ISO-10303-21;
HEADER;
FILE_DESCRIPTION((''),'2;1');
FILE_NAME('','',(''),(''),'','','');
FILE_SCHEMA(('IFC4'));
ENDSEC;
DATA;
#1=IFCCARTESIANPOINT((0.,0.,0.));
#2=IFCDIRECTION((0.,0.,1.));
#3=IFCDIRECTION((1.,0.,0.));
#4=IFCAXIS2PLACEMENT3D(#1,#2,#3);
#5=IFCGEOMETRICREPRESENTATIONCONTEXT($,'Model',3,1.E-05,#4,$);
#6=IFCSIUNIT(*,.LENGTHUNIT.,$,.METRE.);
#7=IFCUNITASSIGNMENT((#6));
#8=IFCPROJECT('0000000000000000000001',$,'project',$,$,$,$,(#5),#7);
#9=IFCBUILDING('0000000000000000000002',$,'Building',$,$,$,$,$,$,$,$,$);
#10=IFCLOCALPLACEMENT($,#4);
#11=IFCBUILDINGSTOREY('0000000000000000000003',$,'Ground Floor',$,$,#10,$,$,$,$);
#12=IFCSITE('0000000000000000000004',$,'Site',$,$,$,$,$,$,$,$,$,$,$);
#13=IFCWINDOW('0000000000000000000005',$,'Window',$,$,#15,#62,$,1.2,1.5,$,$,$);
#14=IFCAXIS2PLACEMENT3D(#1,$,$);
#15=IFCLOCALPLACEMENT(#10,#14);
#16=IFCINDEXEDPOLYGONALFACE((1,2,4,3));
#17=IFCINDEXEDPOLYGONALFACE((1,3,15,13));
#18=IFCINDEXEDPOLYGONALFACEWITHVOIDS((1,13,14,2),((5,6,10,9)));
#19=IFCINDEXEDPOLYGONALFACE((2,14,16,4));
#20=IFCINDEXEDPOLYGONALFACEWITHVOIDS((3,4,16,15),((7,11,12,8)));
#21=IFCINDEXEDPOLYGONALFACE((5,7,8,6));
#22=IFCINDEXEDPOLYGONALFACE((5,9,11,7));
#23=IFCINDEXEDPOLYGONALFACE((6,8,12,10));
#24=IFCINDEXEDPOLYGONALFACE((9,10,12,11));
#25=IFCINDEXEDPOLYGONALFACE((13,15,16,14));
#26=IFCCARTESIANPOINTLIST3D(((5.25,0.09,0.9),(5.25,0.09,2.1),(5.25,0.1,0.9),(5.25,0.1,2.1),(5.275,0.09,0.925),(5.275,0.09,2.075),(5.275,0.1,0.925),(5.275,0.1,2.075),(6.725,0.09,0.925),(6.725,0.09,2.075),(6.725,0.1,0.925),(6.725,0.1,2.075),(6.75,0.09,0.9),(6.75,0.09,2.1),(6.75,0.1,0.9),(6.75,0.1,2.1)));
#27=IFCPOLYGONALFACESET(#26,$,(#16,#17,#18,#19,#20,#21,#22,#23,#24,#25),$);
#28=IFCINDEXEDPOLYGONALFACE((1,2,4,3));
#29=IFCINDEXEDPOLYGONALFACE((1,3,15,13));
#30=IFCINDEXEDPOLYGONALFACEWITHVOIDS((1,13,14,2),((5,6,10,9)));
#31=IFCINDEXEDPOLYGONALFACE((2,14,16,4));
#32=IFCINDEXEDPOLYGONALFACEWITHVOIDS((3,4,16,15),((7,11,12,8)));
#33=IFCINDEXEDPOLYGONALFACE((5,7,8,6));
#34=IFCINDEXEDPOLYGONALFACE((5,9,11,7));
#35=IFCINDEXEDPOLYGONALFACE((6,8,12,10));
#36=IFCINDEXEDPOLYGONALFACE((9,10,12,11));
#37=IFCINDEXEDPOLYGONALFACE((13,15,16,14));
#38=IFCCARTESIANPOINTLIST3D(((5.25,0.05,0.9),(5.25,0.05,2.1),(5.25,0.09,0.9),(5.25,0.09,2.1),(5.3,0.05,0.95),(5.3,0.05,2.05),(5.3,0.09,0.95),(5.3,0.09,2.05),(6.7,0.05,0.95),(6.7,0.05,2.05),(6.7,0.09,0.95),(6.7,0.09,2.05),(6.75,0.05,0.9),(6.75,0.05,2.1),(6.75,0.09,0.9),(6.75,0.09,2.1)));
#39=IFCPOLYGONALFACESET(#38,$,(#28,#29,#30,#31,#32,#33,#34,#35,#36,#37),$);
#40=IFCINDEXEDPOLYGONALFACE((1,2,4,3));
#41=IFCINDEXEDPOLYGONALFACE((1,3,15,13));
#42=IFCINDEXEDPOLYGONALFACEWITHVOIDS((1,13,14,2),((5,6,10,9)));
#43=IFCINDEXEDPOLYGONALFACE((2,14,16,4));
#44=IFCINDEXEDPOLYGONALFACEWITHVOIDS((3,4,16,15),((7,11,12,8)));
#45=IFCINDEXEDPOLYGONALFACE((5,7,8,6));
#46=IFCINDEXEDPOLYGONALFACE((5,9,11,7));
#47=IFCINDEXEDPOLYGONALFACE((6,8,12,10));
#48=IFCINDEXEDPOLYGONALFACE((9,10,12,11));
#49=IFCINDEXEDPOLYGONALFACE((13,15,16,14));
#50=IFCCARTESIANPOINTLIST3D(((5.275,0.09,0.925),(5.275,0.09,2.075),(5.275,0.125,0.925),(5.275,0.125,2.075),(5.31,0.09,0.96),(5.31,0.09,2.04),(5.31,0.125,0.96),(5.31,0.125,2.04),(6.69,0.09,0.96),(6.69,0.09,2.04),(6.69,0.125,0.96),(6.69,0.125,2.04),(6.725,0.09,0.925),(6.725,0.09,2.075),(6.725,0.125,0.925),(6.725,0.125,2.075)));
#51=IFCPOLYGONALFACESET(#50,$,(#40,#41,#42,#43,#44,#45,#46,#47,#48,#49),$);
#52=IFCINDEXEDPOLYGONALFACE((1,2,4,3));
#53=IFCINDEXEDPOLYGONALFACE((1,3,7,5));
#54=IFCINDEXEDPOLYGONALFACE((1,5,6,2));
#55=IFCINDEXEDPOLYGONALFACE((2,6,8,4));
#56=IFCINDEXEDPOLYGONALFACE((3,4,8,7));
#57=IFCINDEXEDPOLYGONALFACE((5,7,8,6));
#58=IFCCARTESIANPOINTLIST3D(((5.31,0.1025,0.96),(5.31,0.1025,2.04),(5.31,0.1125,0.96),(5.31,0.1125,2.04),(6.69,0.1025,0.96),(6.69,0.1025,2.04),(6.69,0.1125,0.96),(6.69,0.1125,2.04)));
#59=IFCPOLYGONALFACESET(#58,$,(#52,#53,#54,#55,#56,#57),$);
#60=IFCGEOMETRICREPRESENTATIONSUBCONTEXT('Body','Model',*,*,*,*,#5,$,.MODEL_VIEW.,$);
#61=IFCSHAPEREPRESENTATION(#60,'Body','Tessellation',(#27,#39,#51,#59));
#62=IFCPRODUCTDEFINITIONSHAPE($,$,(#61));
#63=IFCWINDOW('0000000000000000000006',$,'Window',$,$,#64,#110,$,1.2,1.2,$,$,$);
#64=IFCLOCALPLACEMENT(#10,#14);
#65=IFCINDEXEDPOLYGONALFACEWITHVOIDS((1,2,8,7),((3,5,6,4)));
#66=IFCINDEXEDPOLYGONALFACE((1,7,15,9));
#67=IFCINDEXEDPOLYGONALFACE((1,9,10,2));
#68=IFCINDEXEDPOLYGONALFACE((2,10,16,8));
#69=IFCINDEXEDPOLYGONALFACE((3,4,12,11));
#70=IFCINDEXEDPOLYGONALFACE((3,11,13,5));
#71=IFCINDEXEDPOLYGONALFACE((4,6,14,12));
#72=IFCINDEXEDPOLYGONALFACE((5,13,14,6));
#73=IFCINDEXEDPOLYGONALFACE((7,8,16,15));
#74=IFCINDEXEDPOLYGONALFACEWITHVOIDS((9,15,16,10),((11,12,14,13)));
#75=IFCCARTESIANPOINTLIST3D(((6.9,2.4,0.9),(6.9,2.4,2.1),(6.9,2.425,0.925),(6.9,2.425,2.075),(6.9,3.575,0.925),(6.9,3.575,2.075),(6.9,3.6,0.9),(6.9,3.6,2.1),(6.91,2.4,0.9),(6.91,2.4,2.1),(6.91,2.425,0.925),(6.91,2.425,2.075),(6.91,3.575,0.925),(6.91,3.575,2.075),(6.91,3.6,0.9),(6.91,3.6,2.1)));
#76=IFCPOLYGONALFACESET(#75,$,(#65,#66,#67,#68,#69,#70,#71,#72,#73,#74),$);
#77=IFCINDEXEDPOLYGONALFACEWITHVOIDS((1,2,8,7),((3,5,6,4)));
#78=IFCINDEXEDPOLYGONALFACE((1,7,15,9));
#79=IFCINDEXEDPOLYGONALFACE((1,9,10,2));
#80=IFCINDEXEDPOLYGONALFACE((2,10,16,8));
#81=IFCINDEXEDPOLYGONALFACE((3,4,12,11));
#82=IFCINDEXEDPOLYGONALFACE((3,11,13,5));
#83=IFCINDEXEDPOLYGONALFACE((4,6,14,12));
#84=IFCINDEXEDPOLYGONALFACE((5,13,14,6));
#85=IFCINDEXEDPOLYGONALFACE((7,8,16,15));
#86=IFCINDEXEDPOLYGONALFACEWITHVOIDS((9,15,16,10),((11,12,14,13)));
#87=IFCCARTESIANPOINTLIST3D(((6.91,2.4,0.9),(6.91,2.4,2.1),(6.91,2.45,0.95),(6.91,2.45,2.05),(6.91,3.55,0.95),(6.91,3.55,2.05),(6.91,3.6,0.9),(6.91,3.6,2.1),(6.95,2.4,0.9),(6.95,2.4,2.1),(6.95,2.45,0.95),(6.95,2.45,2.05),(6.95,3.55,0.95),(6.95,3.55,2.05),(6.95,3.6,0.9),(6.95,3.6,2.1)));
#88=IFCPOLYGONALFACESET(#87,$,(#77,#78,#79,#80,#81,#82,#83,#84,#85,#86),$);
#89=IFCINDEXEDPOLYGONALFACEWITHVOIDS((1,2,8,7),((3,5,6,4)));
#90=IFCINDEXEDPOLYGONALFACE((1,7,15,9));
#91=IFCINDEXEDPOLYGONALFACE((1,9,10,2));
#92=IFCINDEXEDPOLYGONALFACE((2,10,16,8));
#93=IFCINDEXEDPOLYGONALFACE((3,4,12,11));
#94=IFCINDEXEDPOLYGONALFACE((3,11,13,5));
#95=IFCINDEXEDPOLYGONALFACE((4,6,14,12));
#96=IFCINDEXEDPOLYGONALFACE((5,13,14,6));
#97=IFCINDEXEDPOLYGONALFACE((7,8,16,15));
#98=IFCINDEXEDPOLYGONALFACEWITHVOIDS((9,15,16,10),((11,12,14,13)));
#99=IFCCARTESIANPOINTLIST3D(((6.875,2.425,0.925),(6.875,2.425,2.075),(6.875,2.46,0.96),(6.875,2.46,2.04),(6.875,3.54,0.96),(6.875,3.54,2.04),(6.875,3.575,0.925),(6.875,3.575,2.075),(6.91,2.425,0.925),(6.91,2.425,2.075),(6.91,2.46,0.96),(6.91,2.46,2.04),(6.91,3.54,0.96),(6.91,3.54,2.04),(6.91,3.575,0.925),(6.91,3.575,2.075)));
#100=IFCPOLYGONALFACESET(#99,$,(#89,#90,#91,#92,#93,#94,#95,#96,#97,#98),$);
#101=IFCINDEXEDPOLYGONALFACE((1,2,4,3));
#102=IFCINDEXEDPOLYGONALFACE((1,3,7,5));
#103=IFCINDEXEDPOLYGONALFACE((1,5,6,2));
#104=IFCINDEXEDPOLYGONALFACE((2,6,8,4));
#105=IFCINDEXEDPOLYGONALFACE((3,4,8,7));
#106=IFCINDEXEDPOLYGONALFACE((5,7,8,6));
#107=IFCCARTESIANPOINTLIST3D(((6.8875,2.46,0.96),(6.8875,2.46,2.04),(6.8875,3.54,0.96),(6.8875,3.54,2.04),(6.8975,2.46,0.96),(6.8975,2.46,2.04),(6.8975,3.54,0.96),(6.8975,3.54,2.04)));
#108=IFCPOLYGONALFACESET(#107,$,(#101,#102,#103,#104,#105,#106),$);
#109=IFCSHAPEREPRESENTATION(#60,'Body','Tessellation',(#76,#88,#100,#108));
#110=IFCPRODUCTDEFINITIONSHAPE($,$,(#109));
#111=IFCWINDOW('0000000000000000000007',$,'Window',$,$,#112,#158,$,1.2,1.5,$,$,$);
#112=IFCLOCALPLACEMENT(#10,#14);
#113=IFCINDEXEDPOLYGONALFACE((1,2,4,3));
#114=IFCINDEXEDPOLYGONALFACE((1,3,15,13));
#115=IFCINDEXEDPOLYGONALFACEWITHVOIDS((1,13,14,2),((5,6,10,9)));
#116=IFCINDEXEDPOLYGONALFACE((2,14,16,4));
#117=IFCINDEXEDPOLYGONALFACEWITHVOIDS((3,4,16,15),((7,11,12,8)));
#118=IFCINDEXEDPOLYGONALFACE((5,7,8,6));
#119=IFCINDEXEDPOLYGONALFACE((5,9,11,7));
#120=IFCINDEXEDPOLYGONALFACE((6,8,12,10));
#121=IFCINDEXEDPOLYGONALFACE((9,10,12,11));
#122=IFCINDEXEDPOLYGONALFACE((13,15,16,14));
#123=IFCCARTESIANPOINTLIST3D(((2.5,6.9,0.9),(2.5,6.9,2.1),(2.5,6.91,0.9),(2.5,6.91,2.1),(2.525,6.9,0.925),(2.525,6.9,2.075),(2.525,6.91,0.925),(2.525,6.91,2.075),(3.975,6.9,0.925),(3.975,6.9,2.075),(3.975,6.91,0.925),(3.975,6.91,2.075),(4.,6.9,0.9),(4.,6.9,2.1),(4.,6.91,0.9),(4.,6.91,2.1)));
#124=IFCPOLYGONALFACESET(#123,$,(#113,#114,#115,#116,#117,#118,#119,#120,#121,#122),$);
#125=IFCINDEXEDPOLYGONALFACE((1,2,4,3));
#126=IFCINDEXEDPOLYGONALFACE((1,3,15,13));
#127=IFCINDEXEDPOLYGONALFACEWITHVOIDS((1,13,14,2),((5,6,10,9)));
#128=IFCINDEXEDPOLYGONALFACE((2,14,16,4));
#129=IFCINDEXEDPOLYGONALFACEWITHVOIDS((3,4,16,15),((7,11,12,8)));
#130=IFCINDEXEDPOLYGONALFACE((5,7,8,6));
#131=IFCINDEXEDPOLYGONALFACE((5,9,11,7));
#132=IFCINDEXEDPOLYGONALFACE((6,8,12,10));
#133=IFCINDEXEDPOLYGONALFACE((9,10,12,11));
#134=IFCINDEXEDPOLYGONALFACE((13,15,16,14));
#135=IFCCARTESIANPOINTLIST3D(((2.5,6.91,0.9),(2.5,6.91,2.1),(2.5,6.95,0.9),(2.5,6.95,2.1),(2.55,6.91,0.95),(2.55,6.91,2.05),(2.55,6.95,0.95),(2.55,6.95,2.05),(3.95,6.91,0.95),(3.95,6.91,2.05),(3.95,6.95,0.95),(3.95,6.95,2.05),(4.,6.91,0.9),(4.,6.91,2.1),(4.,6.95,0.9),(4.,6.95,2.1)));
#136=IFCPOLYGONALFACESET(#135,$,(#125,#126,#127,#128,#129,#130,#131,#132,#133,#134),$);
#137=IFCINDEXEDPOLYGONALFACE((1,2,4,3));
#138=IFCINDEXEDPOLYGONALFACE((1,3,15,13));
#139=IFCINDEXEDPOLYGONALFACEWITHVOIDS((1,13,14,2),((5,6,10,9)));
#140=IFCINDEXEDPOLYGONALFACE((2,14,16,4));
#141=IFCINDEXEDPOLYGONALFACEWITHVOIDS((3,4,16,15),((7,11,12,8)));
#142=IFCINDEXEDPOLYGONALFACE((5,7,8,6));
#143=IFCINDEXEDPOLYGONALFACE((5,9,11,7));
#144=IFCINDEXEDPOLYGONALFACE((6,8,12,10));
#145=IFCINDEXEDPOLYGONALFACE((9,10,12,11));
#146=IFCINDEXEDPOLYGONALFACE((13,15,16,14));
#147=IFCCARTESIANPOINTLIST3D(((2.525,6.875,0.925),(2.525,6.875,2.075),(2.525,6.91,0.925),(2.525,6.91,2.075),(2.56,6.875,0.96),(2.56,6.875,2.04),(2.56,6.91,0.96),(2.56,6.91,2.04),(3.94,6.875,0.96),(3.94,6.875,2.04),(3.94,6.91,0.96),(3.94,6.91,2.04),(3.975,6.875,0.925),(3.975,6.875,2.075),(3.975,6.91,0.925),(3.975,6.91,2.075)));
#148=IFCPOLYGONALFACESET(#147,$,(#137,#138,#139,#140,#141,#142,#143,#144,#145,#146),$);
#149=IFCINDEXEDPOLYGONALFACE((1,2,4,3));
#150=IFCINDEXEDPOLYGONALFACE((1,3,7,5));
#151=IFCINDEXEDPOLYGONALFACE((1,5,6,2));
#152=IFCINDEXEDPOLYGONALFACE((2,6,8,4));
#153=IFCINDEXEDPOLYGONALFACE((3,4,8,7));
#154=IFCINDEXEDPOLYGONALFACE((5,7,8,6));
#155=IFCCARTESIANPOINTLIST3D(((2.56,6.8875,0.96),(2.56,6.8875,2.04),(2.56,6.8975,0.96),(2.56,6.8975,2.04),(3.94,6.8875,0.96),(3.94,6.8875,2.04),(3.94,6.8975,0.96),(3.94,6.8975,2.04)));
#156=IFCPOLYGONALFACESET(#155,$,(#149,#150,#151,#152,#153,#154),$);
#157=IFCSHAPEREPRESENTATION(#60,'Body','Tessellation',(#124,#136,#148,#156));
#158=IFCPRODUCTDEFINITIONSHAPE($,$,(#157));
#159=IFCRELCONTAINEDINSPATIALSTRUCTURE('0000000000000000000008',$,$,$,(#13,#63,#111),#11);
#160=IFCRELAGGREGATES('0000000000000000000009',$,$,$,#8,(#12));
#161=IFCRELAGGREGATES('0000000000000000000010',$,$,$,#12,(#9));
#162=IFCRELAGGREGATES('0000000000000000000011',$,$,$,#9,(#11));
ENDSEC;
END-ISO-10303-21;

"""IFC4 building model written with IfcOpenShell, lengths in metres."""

from ifc_helpers import new_model, si_unit, frame, origin_with_axes, place, context, subcontext, project, spatial, line, indexed_curve, outline, extrude, element, save


model = new_model("IFC4")

# Units and contexts
model_context = context("Model", 3, precision=1e-05, world=origin_with_axes())
body_context = subcontext(model_context, "Body", "Model", "MODEL_VIEW")
ifc_project = project(units=[si_unit("LENGTHUNIT", "METRE")], contexts=[model_context])

# Site, building, storey
site = spatial("IfcSite", under=ifc_project, Name="Site")
building = spatial("IfcBuilding", under=site, Name="Building")
storey_placement = place(None, origin_with_axes())
storey = spatial("IfcBuildingStorey", under=building, at=storey_placement, Name="Ground Floor")

# Windows
window_1_placement = place(storey_placement, frame((5.25, 0.0, 0.9), z_axis=(0.0, 0.0, 1.0), x_axis=(1.0, 0.0, 0.0)))
element("IfcWindow", 1, at=window_1_placement, inside=storey, Name="Window", OverallHeight=1.2, OverallWidth=1.5, context=body_context, shape_type="SweptSolid", body=[
    extrude(outline(indexed_curve([(0.0, 0.0), (1.5, 0.0), (1.5, 1.2), (0.0, 1.2)], segments=[line(1, 2, 3, 4, 1)]), holes=[indexed_curve([(0.025, 0.025), (1.475, 0.025), (1.475, 1.175), (0.025, 1.175)], segments=[line(1, 2, 3, 4, 1)])]), frame((0.0, 0.09, 0.0), z_axis=(0.0, -1.0, 0.0), x_axis=(1.0, 0.0, 0.0)), (0.0, 0.0, -1.0), 0.01),
    extrude(outline(indexed_curve([(0.0, 0.0), (1.5, 0.0), (1.5, 1.2), (0.0, 1.2)], segments=[line(1, 2, 3, 4, 1)]), holes=[indexed_curve([(0.05, 0.05), (1.45, 0.05), (1.45, 1.15), (0.05, 1.15)], segments=[line(1, 2, 3, 4, 1)])]), frame((0.0, 0.05, 0.0), z_axis=(0.0, -1.0, 0.0), x_axis=(1.0, 0.0, 0.0)), (0.0, 0.0, -1.0), 0.04),
    extrude(outline(indexed_curve([(0.0, 0.0), (1.45, 0.0), (1.45, 1.15), (0.0, 1.15)], segments=[line(1, 2, 3, 4, 1)]), holes=[indexed_curve([(0.035, 0.035), (1.415, 0.035), (1.415, 1.115), (0.035, 1.115)], segments=[line(1, 2, 3, 4, 1)])]), frame((0.025, 0.09, 0.025), z_axis=(0.0, -1.0, 0.0), x_axis=(1.0, 0.0, 0.0)), (0.0, 0.0, -1.0), 0.035),
    extrude(outline(indexed_curve([(0.035, 0.035), (1.415, 0.035), (1.415, 1.115), (0.035, 1.115)], segments=[line(1, 2, 3, 4, 1)])), frame((0.025, 0.1025, 0.025), z_axis=(0.0, -1.0, 0.0), x_axis=(1.0, 0.0, 0.0)), (0.0, 0.0, -1.0), 0.01),
])
window_2_placement = place(storey_placement, frame((7.0, 2.4, 0.9), z_axis=(0.0, 0.0, 1.0), x_axis=(0.0, 1.0, 0.0)))
element("IfcWindow", 2, at=window_2_placement, inside=storey, Name="Window", OverallHeight=1.2, OverallWidth=1.2, context=body_context, shape_type="SweptSolid", body=[
    extrude(outline(indexed_curve([(0.0, 0.0), (1.2, 0.0), (1.2, 1.2), (0.0, 1.2)], segments=[line(1, 2, 3, 4, 1)]), holes=[indexed_curve([(0.025, 0.025), (1.175, 0.025), (1.175, 1.175), (0.025, 1.175)], segments=[line(1, 2, 3, 4, 1)])]), frame((0.0, 0.09, 0.0), z_axis=(0.0, -1.0, 0.0), x_axis=(1.0, 0.0, 0.0)), (0.0, 0.0, -1.0), 0.01),
    extrude(outline(indexed_curve([(0.0, 0.0), (1.2, 0.0), (1.2, 1.2), (0.0, 1.2)], segments=[line(1, 2, 3, 4, 1)]), holes=[indexed_curve([(0.05, 0.05), (1.15, 0.05), (1.15, 1.15), (0.05, 1.15)], segments=[line(1, 2, 3, 4, 1)])]), frame((0.0, 0.05, 0.0), z_axis=(0.0, -1.0, 0.0), x_axis=(1.0, 0.0, 0.0)), (0.0, 0.0, -1.0), 0.04),
    extrude(outline(indexed_curve([(0.0, 0.0), (1.15, 0.0), (1.15, 1.15), (0.0, 1.15)], segments=[line(1, 2, 3, 4, 1)]), holes=[indexed_curve([(0.035, 0.035), (1.115, 0.035), (1.115, 1.115), (0.035, 1.115)], segments=[line(1, 2, 3, 4, 1)])]), frame((0.025, 0.09, 0.025), z_axis=(0.0, -1.0, 0.0), x_axis=(1.0, 0.0, 0.0)), (0.0, 0.0, -1.0), 0.035),
    extrude(outline(indexed_curve([(0.035, 0.035), (1.115, 0.035), (1.115, 1.115), (0.035, 1.115)], segments=[line(1, 2, 3, 4, 1)])), frame((0.025, 0.1025, 0.025), z_axis=(0.0, -1.0, 0.0), x_axis=(1.0, 0.0, 0.0)), (0.0, 0.0, -1.0), 0.01),
])
window_3_placement = place(storey_placement, frame((4.0, 7.0, 0.9), z_axis=(0.0, 0.0, 1.0), x_axis=(-1.0, 0.0, 0.0)))
element("IfcWindow", 3, at=window_3_placement, inside=storey, Name="Window", OverallHeight=1.2, OverallWidth=1.5, context=body_context, shape_type="SweptSolid", body=[
    extrude(outline(indexed_curve([(0.0, 0.0), (1.5, 0.0), (1.5, 1.2), (0.0, 1.2)], segments=[line(1, 2, 3, 4, 1)]), holes=[indexed_curve([(0.025, 0.025), (1.475, 0.025), (1.475, 1.175), (0.025, 1.175)], segments=[line(1, 2, 3, 4, 1)])]), frame((0.0, 0.09, 0.0), z_axis=(0.0, -1.0, 0.0), x_axis=(1.0, 0.0, 0.0)), (0.0, 0.0, -1.0), 0.01),
    extrude(outline(indexed_curve([(0.0, 0.0), (1.5, 0.0), (1.5, 1.2), (0.0, 1.2)], segments=[line(1, 2, 3, 4, 1)]), holes=[indexed_curve([(0.05, 0.05), (1.45, 0.05), (1.45, 1.15), (0.05, 1.15)], segments=[line(1, 2, 3, 4, 1)])]), frame((0.0, 0.05, 0.0), z_axis=(0.0, -1.0, 0.0), x_axis=(1.0, 0.0, 0.0)), (0.0, 0.0, -1.0), 0.04),
    extrude(outline(indexed_curve([(0.0, 0.0), (1.45, 0.0), (1.45, 1.15), (0.0, 1.15)], segments=[line(1, 2, 3, 4, 1)]), holes=[indexed_curve([(0.035, 0.035), (1.415, 0.035), (1.415, 1.115), (0.035, 1.115)], segments=[line(1, 2, 3, 4, 1)])]), frame((0.025, 0.09, 0.025), z_axis=(0.0, -1.0, 0.0), x_axis=(1.0, 0.0, 0.0)), (0.0, 0.0, -1.0), 0.035),
    extrude(outline(indexed_curve([(0.035, 0.035), (1.415, 0.035), (1.415, 1.115), (0.035, 1.115)], segments=[line(1, 2, 3, 4, 1)])), frame((0.025, 0.1025, 0.025), z_axis=(0.0, -1.0, 0.0), x_axis=(1.0, 0.0, 0.0)), (0.0, 0.0, -1.0), 0.01),
])

save(model, "model.ifc")
